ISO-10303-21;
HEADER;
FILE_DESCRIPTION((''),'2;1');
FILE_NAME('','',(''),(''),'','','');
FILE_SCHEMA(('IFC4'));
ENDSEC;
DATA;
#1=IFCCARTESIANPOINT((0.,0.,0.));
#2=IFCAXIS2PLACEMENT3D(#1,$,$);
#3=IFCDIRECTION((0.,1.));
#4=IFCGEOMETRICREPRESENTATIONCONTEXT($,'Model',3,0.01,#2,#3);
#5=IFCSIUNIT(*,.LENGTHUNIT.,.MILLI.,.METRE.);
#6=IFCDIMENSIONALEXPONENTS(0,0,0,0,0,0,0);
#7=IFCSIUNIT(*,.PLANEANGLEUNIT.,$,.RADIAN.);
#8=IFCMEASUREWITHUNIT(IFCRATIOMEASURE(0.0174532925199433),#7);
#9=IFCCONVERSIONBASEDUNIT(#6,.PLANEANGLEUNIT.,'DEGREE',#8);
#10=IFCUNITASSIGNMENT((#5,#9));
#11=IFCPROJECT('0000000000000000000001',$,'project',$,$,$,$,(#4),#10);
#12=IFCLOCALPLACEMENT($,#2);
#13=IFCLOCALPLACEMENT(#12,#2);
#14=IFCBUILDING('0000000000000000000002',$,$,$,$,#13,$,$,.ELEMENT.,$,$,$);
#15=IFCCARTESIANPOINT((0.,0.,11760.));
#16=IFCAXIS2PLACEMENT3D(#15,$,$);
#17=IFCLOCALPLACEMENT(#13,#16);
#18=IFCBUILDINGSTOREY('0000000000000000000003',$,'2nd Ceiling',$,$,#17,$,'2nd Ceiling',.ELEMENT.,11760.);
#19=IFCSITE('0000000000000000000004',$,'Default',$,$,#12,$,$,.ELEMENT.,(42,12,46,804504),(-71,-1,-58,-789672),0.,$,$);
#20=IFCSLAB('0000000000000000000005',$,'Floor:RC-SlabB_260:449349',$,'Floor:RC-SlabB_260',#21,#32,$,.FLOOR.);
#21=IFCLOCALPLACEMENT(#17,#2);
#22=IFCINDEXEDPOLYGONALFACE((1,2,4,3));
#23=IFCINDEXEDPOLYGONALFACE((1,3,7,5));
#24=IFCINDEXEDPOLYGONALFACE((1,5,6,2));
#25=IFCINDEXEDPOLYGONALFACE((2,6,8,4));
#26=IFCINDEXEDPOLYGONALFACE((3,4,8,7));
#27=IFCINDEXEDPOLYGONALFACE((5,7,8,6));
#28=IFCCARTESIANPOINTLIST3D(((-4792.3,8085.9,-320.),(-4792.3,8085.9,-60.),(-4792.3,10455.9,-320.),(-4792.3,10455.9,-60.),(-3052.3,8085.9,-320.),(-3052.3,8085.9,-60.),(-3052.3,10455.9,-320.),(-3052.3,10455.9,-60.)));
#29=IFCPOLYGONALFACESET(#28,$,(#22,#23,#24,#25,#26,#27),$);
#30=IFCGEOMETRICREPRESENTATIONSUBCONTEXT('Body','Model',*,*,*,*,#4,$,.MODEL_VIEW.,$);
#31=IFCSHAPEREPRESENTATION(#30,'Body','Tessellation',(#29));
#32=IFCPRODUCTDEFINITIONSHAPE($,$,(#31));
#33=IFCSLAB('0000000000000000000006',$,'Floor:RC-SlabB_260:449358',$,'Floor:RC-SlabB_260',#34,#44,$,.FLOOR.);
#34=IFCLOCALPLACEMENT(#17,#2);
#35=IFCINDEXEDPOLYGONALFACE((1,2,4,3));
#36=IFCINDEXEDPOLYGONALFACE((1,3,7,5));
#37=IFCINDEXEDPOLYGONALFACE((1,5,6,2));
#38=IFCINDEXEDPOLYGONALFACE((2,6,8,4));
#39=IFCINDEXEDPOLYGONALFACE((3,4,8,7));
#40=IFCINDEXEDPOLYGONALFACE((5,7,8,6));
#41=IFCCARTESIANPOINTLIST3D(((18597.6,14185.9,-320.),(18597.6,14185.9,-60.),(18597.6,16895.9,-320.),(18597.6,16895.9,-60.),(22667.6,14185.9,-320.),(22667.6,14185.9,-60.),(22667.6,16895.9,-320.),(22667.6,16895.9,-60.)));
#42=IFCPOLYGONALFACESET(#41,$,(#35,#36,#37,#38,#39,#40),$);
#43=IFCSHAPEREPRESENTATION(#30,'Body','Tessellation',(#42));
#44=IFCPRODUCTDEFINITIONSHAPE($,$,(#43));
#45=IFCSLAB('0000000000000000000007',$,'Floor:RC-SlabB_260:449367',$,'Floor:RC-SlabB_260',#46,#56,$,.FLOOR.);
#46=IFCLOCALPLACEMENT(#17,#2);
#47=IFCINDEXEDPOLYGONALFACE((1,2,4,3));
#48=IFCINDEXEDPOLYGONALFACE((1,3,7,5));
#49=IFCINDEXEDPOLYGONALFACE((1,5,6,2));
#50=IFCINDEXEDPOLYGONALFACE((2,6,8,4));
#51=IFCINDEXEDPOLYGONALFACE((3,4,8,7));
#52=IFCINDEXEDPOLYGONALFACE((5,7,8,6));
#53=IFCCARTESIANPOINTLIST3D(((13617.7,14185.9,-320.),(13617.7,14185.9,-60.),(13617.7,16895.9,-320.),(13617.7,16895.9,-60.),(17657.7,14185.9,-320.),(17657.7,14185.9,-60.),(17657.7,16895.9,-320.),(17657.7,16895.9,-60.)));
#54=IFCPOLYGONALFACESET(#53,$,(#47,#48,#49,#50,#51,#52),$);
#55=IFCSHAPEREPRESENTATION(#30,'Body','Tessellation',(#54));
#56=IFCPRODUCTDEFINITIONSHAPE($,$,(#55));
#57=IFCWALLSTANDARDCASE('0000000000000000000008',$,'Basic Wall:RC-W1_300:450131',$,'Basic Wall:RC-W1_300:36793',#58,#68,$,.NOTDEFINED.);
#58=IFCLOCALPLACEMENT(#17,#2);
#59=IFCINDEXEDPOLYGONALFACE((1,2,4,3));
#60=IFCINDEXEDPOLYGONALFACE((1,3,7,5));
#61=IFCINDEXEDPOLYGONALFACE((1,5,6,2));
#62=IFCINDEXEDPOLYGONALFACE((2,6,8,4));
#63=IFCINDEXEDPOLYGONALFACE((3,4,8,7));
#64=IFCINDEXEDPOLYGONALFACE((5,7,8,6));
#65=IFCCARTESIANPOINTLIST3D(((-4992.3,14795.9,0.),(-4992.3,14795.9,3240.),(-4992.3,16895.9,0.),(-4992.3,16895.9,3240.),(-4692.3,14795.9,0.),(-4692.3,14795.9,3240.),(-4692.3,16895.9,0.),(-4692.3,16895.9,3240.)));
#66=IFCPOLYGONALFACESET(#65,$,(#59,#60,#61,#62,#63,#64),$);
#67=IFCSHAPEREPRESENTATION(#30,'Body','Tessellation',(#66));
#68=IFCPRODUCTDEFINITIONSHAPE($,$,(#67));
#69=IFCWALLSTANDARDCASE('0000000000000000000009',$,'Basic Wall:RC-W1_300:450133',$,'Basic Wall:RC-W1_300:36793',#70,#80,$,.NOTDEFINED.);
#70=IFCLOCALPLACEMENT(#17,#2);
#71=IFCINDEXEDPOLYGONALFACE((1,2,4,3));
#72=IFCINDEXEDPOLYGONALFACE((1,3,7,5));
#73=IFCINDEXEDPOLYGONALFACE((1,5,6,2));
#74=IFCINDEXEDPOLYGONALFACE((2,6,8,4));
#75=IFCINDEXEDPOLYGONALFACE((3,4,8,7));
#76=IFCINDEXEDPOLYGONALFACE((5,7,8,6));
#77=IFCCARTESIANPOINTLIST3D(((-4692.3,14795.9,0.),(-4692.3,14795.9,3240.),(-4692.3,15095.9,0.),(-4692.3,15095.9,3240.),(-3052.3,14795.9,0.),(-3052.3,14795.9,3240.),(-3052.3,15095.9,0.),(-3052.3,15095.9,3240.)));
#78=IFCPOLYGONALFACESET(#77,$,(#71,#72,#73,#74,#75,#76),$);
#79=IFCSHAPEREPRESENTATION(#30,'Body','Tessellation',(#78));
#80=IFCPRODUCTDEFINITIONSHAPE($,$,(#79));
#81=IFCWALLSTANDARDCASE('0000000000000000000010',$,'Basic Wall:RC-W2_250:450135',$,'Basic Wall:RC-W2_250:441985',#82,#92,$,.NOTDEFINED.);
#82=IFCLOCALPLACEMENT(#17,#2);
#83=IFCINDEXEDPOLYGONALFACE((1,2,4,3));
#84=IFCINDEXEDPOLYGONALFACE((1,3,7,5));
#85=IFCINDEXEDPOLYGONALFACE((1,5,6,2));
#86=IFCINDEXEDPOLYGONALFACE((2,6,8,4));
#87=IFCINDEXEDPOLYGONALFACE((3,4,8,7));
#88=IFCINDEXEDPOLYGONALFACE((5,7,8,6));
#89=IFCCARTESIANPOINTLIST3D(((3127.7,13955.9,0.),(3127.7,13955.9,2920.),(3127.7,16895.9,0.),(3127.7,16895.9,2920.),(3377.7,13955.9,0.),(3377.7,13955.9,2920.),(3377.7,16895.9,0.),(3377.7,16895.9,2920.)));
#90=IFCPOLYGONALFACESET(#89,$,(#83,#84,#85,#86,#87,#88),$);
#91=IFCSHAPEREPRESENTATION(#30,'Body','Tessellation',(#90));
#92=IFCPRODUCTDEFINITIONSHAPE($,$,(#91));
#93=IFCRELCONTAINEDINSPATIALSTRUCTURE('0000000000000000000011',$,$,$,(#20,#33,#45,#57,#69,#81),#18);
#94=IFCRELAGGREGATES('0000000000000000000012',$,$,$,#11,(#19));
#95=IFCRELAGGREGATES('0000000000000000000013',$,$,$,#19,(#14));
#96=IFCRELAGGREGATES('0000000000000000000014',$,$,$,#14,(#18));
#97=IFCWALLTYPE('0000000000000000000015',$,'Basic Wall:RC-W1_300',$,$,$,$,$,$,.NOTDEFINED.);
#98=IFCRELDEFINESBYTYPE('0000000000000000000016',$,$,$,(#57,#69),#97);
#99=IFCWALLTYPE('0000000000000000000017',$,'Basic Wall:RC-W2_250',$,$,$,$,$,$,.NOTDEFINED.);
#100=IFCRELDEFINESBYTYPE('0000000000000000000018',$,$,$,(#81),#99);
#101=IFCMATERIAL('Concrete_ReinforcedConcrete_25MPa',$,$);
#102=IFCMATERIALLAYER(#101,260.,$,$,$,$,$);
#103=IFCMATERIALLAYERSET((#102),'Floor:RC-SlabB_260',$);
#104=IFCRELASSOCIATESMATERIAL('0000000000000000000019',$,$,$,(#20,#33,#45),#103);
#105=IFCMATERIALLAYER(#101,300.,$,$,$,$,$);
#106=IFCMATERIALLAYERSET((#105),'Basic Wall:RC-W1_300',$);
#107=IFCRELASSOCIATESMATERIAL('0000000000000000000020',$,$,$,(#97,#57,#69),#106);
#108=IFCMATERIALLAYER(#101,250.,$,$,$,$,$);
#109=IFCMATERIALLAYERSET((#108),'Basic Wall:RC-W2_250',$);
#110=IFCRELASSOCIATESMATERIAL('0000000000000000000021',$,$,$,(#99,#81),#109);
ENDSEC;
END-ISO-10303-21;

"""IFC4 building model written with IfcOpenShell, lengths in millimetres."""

from ifc_helpers import new_model, entity, si_unit, converted_unit, direction, frame, frame_2d, origin, origin_2d_with_axis, place, context, subcontext, project, spatial, polyline, rectangle, extrude, clip, bounded_halfspace, material, layer, layer_set, layer_usage, type_object, element, save


model = new_model("IFC4")

# Units and contexts
model_context = context("Model", 3, precision=0.01, world=origin(), true_north=direction((0.0, 1.0)))
body_context = subcontext(model_context, "Body", "Model", "MODEL_VIEW")
ifc_project = project(units=[si_unit("LENGTHUNIT", "METRE", prefix="MILLI"), converted_unit("PLANEANGLEUNIT", "DEGREE", entity("IfcRatioMeasure", 0.0174532925199433), si_unit("PLANEANGLEUNIT", "RADIAN"), dimensions=[0, 0, 0, 0, 0, 0, 0])], contexts=[model_context])

# Site, building, storey
site_placement = place(None, origin())
site = spatial("IfcSite", under=ifc_project, at=site_placement, Name="Default", CompositionType="ELEMENT", RefLatitude=(42, 12, 46, 804504), RefLongitude=(-71, -1, -58, -789672), RefElevation=0.0)
building_placement = place(site_placement, origin())
building = spatial("IfcBuilding", under=site, at=building_placement, CompositionType="ELEMENT")
storey_placement = place(building_placement, frame((0.0, 0.0, 11760.0)))
storey = spatial("IfcBuildingStorey", under=building, at=storey_placement, Name="2nd Ceiling", LongName="2nd Ceiling", CompositionType="ELEMENT", Elevation=11760.0)

# Shared definitions
ifc_material = material(Name="Concrete_ReinforcedConcrete_25MPa")

# Slabs
ifc_layer_1 = layer(ifc_material, 260.0)
ifc_layer_set_1 = layer_set([ifc_layer_1], Name="Floor:RC-SlabB_260")
ifc_layer_usage_1 = layer_usage(ifc_layer_set_1, "AXIS3", "POSITIVE", 0.0)
slab_1_placement = place(storey_placement, origin())
element("IfcSlab", 1, at=slab_1_placement, inside=storey, material=ifc_layer_usage_1, Name="Floor:RC-SlabB_260:449349", ObjectType="Floor:RC-SlabB_260", PredefinedType="FLOOR", context=body_context, shape_type="SweptSolid", body=[
    extrude(rectangle(XDim=2370.0, YDim=1740.0, at=frame_2d((0.0, 0.0), x_axis=(1.0, 0.0))), frame((-3922.3, 9270.9, -60.0), z_axis=(0.0, 0.0, -1.0), x_axis=(0.0, 1.0, 0.0)), (0.0, 0.0, 1.0), 260.0),
])
ifc_layer_usage_2 = layer_usage(ifc_layer_set_1, "AXIS3", "POSITIVE", 0.0)
slab_2_placement = place(storey_placement, origin())
element("IfcSlab", 2, at=slab_2_placement, inside=storey, material=ifc_layer_usage_2, Name="Floor:RC-SlabB_260:449358", ObjectType="Floor:RC-SlabB_260", PredefinedType="FLOOR", context=body_context, shape_type="SweptSolid", body=[
    extrude(rectangle(XDim=2710.0, YDim=4070.0, at=frame_2d((0.0, 0.0), x_axis=(1.0, 0.0))), frame((20632.6, 15540.9, -60.0), z_axis=(0.0, 0.0, -1.0), x_axis=(0.0, 1.0, 0.0)), (0.0, 0.0, 1.0), 260.0),
])
ifc_layer_usage_3 = layer_usage(ifc_layer_set_1, "AXIS3", "POSITIVE", 0.0)
slab_3_placement = place(storey_placement, origin())
element("IfcSlab", 3, at=slab_3_placement, inside=storey, material=ifc_layer_usage_3, Name="Floor:RC-SlabB_260:449367", ObjectType="Floor:RC-SlabB_260", PredefinedType="FLOOR", context=body_context, shape_type="SweptSolid", body=[
    extrude(rectangle(XDim=2710.0, YDim=4040.0, at=origin_2d_with_axis()), frame((15637.7, 15540.9, -60.0), z_axis=(0.0, 0.0, -1.0), x_axis=(0.0, 1.0, 0.0)), (0.0, 0.0, 1.0), 260.0),
])

# Walls
ifc_layer_2 = layer(ifc_material, 300.0)
ifc_layer_set_2 = layer_set([ifc_layer_2], Name="Basic Wall:RC-W1_300")
ifc_layer_usage_4 = layer_usage(ifc_layer_set_2, "AXIS2", "NEGATIVE", 150.0)
wall_type_1 = type_object("IfcWallType", Name="Basic Wall:RC-W1_300", PredefinedType="NOTDEFINED", material=ifc_layer_set_2)
wall_1_placement = place(storey_placement, frame((-4842.3, 16895.9, 0.0), z_axis=(0.0, 0.0, 1.0), x_axis=(0.0, -1.0, 0.0)))
element("IfcWallStandardCase", 4, at=wall_1_placement, inside=storey, type_object=wall_type_1, material=ifc_layer_usage_4, Name="Basic Wall:RC-W1_300:450131", ObjectType="Basic Wall:RC-W1_300:36793", PredefinedType="NOTDEFINED", context=body_context, shape_type="SweptSolid", body=[
    extrude(rectangle(XDim=2100.0, YDim=300.0, at=frame_2d((1050.0, 0.0), x_axis=(-1.0, 0.0))), origin(), (0.0, 0.0, 1.0), 3240.0),
])
ifc_layer_usage_5 = layer_usage(ifc_layer_set_2, "AXIS2", "NEGATIVE", 150.0)
wall_2_placement = place(storey_placement, frame((-4692.3, 14945.9, 0.0)))
element("IfcWallStandardCase", 5, at=wall_2_placement, inside=storey, type_object=wall_type_1, material=ifc_layer_usage_5, Name="Basic Wall:RC-W1_300:450133", ObjectType="Basic Wall:RC-W1_300:36793", PredefinedType="NOTDEFINED", context=body_context, shape_type="SweptSolid", body=[
    extrude(rectangle(XDim=1640.0, YDim=300.0, at=frame_2d((820.0, 0.0), x_axis=(-1.0, 0.0))), origin(), (0.0, 0.0, 1.0), 3240.0),
])
ifc_layer_3 = layer(ifc_material, 250.0)
ifc_layer_set_3 = layer_set([ifc_layer_3], Name="Basic Wall:RC-W2_250")
ifc_layer_usage_6 = layer_usage(ifc_layer_set_3, "AXIS2", "NEGATIVE", 125.0)
wall_type_2 = type_object("IfcWallType", Name="Basic Wall:RC-W2_250", PredefinedType="NOTDEFINED", material=ifc_layer_set_3)
wall_3_placement = place(storey_placement, frame((3252.7, 13955.9, 0.0), z_axis=(0.0, 0.0, 1.0), x_axis=(0.0, 1.0, 0.0)))
element("IfcWallStandardCase", 6, at=wall_3_placement, inside=storey, type_object=wall_type_2, material=ifc_layer_usage_6, Name="Basic Wall:RC-W2_250:450135", ObjectType="Basic Wall:RC-W2_250:441985", PredefinedType="NOTDEFINED", context=body_context, shape_type="Clipping", body=[
    clip(extrude(rectangle(XDim=2940.0, YDim=250.0, at=frame_2d((1470.0, 0.0), x_axis=(-1.0, 0.0))), origin(), (0.0, 0.0, 1.0), 2920.0), bounded_halfspace(frame((0.0, -125.0, 2920.0), z_axis=(0.0, 0.0, -1.0), x_axis=(0.0, -1.0, 0.0)), True, frame((0.0, -125.0, 2920.0), z_axis=(0.0, 0.0, -1.0), x_axis=(0.0, -1.0, 0.0)), polyline([(0.0, 0.0), (-250.0, 0.0), (-250.0, -2940.0), (0.0, -2940.0), (0.0, 0.0)]))),
])

save(model, "model.ifc")
